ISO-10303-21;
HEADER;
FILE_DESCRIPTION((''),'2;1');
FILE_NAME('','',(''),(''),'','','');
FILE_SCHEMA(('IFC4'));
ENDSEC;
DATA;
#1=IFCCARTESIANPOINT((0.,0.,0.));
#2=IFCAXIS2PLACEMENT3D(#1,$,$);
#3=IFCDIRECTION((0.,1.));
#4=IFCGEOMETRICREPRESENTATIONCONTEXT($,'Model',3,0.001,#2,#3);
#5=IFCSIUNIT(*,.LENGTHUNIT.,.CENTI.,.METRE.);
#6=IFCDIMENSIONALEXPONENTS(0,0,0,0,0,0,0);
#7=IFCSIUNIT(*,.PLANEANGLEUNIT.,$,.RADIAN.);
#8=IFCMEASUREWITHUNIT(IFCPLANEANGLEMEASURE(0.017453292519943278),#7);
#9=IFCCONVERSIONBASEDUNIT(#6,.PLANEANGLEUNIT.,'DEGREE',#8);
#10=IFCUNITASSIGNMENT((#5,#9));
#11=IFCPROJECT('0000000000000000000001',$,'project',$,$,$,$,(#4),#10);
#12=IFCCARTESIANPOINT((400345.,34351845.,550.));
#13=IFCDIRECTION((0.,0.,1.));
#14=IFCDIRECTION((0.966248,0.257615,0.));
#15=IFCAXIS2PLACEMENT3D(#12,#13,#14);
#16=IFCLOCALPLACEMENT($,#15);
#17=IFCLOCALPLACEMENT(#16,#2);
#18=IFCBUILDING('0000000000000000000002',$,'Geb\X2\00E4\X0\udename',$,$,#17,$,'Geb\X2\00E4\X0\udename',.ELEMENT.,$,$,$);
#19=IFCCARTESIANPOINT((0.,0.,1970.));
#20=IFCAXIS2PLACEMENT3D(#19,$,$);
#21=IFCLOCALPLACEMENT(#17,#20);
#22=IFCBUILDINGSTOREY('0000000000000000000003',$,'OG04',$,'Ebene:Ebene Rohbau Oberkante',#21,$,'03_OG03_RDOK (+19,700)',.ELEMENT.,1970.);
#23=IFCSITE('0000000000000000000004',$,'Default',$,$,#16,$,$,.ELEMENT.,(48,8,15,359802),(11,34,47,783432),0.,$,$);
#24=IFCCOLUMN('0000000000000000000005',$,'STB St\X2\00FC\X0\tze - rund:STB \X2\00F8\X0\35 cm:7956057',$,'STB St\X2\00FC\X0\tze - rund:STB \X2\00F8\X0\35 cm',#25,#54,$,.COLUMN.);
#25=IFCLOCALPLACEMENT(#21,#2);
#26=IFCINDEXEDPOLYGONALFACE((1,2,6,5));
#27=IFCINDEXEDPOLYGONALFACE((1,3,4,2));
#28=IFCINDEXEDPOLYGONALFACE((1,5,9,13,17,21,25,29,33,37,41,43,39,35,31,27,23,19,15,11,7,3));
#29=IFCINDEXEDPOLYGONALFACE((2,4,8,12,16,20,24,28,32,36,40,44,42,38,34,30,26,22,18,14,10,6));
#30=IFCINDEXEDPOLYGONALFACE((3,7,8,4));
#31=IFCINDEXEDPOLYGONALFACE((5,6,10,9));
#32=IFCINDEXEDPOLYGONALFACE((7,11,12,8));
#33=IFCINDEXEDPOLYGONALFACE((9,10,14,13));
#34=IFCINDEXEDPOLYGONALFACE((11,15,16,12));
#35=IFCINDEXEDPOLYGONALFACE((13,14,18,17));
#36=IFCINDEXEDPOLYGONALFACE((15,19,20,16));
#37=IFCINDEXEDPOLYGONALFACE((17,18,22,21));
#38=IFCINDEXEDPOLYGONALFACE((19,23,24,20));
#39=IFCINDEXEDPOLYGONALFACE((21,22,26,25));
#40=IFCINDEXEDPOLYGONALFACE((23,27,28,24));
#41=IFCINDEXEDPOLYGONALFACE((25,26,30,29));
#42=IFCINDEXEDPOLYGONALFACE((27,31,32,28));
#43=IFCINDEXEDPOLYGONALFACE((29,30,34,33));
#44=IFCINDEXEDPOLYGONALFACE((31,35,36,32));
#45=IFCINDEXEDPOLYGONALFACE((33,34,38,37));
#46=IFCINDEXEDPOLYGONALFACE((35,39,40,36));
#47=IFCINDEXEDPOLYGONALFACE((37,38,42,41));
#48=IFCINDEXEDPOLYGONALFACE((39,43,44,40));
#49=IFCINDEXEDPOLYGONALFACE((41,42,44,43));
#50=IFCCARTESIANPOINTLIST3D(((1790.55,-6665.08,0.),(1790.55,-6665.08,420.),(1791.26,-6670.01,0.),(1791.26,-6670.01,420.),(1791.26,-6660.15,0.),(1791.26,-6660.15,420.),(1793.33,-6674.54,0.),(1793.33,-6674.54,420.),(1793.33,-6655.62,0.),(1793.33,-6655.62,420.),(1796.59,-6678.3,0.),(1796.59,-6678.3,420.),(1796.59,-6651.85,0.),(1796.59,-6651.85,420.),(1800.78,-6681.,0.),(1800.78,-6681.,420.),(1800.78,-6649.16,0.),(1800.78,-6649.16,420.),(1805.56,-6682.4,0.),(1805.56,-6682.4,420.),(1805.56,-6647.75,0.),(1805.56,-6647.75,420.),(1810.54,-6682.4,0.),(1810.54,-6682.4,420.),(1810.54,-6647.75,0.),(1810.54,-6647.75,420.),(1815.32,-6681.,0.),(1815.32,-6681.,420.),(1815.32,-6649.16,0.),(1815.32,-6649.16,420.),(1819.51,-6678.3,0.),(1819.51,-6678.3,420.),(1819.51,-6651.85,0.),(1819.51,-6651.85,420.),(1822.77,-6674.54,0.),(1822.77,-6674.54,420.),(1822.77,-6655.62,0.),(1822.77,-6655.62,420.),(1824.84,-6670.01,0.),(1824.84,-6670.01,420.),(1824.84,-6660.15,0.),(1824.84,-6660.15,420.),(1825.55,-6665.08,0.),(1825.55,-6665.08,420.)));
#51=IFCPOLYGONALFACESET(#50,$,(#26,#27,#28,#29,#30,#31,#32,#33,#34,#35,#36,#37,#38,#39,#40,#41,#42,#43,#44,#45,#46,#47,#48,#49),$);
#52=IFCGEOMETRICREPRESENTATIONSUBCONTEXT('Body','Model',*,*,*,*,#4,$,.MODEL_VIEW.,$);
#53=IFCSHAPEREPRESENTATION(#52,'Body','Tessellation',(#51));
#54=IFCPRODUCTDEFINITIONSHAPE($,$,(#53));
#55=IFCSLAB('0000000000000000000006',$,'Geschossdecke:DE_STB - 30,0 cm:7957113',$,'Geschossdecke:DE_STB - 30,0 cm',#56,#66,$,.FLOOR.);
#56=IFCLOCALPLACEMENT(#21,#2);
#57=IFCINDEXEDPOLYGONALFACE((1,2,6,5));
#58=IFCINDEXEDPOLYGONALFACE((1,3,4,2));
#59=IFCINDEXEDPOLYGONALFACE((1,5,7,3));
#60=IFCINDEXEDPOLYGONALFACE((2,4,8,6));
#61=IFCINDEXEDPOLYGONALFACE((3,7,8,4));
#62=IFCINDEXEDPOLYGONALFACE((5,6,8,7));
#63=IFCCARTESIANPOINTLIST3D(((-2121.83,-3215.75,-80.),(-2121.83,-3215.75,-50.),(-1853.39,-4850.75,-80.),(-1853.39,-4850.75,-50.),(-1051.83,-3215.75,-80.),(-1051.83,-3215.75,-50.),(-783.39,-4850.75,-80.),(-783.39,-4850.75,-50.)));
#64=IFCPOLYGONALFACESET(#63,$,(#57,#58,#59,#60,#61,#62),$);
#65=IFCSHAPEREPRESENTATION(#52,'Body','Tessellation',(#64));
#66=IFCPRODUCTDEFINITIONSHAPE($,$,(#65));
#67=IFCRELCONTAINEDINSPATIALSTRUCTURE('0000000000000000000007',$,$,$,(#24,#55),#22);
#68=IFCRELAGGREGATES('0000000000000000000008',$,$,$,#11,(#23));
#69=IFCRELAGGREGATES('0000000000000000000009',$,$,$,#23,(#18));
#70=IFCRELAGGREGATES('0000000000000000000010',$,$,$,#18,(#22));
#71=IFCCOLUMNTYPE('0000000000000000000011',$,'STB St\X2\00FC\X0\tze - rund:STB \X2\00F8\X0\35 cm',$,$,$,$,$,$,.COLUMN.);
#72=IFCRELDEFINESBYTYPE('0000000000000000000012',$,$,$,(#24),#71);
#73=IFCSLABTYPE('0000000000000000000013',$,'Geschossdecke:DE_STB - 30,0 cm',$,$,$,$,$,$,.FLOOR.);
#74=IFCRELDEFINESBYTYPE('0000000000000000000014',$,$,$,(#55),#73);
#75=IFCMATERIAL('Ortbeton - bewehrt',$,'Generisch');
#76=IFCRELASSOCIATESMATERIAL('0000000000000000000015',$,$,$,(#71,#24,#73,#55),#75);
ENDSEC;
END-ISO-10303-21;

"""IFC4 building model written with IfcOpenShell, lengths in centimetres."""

from ifc_helpers import new_model, entity, si_unit, converted_unit, direction, frame, origin, place, context, subcontext, project, spatial, arc, indexed_curve, outline, extrude, source, transform, mapped, material, type_object, type_shapes, element, save


model = new_model("IFC4")

# Units and contexts
model_context = context("Model", 3, precision=0.001, world=origin(), true_north=direction((0.0, 1.0)))
body_context = subcontext(model_context, "Body", "Model", "MODEL_VIEW")
ifc_project = project(units=[si_unit("LENGTHUNIT", "METRE", prefix="CENTI"), converted_unit("PLANEANGLEUNIT", "DEGREE", entity("IfcPlaneAngleMeasure", 0.017453292519943278), si_unit("PLANEANGLEUNIT", "RADIAN"), dimensions=[0, 0, 0, 0, 0, 0, 0])], contexts=[model_context])

# Site, building, storey
site_placement = place(None, frame((400345.0, 34351845.0, 550.0), z_axis=(0.0, 0.0, 1.0), x_axis=(0.966248, 0.257615, 0.0)))
site = spatial("IfcSite", under=ifc_project, at=site_placement, Name="Default", CompositionType="ELEMENT", RefLatitude=(48, 8, 15, 359802), RefLongitude=(11, 34, 47, 783432), RefElevation=0.0)
building_placement = place(site_placement, origin())
building = spatial("IfcBuilding", under=site, at=building_placement, Name="Gebäudename", LongName="Gebäudename", CompositionType="ELEMENT")
storey_placement = place(building_placement, frame((0.0, 0.0, 1970.0)))
storey = spatial("IfcBuildingStorey", under=building, at=storey_placement, Name="OG04", ObjectType="Ebene:Ebene Rohbau Oberkante", LongName="03_OG03_RDOK (+19,700)", CompositionType="ELEMENT", Elevation=1970.0)

# Column
ifc_material = material(Name="Ortbeton - bewehrt", Category="Generisch")
column_type_1 = type_object("IfcColumnType", Name="STB Stütze - rund:STB ø35 cm", PredefinedType="COLUMN", material=ifc_material)
shared_shape_1 = source(origin(), body_context, "Body", "SweptSolid", [
    extrude(outline(indexed_curve([(-17.5, 0.0), (0.0, -17.5), (17.5, 0.0), (0.0, 17.5)], segments=[arc(1, 2, 3), arc(3, 4, 1)], self_intersect=False)), frame((1808.05, -6665.08, 1970.0)), (0.0, 0.0, 1.0), 420.0),
])
type_shapes(column_type_1, [shared_shape_1])
column_1_placement = place(storey_placement, frame((0.0, 0.0, -1970.0)))
element("IfcColumn", 1, at=column_1_placement, inside=storey, type_object=column_type_1, material=ifc_material, Name="STB Stütze - rund:STB ø35 cm:7956057", ObjectType="STB Stütze - rund:STB ø35 cm", PredefinedType="COLUMN", context=body_context, shape_type="MappedRepresentation", body=[
    mapped(shared_shape_1, transform((0.0, 0.0, 0.0), scale=1.0)),
])

# Slab
slab_type = type_object("IfcSlabType", Name="Geschossdecke:DE_STB - 30,0 cm", PredefinedType="FLOOR", material=ifc_material)
slab_placement = place(storey_placement, origin())
element("IfcSlab", 2, at=slab_placement, inside=storey, type_object=slab_type, material=ifc_material, Name="Geschossdecke:DE_STB - 30,0 cm:7957113", ObjectType="Geschossdecke:DE_STB - 30,0 cm", PredefinedType="FLOOR", context=body_context, shape_type="SweptSolid", body=[
    extrude(outline(indexed_curve([(-669.22, -817.5), (400.78, -817.5), (669.22, 817.5), (-400.78, 817.5), (-669.22, -817.5)], self_intersect=False)), frame((-1452.61, -4033.25, -50.0), z_axis=(0.0, 0.0, -1.0), x_axis=(-1.0, 0.0, 0.0)), (0.0, 0.0, 1.0), 30.0),
])

save(model, "model.ifc")
